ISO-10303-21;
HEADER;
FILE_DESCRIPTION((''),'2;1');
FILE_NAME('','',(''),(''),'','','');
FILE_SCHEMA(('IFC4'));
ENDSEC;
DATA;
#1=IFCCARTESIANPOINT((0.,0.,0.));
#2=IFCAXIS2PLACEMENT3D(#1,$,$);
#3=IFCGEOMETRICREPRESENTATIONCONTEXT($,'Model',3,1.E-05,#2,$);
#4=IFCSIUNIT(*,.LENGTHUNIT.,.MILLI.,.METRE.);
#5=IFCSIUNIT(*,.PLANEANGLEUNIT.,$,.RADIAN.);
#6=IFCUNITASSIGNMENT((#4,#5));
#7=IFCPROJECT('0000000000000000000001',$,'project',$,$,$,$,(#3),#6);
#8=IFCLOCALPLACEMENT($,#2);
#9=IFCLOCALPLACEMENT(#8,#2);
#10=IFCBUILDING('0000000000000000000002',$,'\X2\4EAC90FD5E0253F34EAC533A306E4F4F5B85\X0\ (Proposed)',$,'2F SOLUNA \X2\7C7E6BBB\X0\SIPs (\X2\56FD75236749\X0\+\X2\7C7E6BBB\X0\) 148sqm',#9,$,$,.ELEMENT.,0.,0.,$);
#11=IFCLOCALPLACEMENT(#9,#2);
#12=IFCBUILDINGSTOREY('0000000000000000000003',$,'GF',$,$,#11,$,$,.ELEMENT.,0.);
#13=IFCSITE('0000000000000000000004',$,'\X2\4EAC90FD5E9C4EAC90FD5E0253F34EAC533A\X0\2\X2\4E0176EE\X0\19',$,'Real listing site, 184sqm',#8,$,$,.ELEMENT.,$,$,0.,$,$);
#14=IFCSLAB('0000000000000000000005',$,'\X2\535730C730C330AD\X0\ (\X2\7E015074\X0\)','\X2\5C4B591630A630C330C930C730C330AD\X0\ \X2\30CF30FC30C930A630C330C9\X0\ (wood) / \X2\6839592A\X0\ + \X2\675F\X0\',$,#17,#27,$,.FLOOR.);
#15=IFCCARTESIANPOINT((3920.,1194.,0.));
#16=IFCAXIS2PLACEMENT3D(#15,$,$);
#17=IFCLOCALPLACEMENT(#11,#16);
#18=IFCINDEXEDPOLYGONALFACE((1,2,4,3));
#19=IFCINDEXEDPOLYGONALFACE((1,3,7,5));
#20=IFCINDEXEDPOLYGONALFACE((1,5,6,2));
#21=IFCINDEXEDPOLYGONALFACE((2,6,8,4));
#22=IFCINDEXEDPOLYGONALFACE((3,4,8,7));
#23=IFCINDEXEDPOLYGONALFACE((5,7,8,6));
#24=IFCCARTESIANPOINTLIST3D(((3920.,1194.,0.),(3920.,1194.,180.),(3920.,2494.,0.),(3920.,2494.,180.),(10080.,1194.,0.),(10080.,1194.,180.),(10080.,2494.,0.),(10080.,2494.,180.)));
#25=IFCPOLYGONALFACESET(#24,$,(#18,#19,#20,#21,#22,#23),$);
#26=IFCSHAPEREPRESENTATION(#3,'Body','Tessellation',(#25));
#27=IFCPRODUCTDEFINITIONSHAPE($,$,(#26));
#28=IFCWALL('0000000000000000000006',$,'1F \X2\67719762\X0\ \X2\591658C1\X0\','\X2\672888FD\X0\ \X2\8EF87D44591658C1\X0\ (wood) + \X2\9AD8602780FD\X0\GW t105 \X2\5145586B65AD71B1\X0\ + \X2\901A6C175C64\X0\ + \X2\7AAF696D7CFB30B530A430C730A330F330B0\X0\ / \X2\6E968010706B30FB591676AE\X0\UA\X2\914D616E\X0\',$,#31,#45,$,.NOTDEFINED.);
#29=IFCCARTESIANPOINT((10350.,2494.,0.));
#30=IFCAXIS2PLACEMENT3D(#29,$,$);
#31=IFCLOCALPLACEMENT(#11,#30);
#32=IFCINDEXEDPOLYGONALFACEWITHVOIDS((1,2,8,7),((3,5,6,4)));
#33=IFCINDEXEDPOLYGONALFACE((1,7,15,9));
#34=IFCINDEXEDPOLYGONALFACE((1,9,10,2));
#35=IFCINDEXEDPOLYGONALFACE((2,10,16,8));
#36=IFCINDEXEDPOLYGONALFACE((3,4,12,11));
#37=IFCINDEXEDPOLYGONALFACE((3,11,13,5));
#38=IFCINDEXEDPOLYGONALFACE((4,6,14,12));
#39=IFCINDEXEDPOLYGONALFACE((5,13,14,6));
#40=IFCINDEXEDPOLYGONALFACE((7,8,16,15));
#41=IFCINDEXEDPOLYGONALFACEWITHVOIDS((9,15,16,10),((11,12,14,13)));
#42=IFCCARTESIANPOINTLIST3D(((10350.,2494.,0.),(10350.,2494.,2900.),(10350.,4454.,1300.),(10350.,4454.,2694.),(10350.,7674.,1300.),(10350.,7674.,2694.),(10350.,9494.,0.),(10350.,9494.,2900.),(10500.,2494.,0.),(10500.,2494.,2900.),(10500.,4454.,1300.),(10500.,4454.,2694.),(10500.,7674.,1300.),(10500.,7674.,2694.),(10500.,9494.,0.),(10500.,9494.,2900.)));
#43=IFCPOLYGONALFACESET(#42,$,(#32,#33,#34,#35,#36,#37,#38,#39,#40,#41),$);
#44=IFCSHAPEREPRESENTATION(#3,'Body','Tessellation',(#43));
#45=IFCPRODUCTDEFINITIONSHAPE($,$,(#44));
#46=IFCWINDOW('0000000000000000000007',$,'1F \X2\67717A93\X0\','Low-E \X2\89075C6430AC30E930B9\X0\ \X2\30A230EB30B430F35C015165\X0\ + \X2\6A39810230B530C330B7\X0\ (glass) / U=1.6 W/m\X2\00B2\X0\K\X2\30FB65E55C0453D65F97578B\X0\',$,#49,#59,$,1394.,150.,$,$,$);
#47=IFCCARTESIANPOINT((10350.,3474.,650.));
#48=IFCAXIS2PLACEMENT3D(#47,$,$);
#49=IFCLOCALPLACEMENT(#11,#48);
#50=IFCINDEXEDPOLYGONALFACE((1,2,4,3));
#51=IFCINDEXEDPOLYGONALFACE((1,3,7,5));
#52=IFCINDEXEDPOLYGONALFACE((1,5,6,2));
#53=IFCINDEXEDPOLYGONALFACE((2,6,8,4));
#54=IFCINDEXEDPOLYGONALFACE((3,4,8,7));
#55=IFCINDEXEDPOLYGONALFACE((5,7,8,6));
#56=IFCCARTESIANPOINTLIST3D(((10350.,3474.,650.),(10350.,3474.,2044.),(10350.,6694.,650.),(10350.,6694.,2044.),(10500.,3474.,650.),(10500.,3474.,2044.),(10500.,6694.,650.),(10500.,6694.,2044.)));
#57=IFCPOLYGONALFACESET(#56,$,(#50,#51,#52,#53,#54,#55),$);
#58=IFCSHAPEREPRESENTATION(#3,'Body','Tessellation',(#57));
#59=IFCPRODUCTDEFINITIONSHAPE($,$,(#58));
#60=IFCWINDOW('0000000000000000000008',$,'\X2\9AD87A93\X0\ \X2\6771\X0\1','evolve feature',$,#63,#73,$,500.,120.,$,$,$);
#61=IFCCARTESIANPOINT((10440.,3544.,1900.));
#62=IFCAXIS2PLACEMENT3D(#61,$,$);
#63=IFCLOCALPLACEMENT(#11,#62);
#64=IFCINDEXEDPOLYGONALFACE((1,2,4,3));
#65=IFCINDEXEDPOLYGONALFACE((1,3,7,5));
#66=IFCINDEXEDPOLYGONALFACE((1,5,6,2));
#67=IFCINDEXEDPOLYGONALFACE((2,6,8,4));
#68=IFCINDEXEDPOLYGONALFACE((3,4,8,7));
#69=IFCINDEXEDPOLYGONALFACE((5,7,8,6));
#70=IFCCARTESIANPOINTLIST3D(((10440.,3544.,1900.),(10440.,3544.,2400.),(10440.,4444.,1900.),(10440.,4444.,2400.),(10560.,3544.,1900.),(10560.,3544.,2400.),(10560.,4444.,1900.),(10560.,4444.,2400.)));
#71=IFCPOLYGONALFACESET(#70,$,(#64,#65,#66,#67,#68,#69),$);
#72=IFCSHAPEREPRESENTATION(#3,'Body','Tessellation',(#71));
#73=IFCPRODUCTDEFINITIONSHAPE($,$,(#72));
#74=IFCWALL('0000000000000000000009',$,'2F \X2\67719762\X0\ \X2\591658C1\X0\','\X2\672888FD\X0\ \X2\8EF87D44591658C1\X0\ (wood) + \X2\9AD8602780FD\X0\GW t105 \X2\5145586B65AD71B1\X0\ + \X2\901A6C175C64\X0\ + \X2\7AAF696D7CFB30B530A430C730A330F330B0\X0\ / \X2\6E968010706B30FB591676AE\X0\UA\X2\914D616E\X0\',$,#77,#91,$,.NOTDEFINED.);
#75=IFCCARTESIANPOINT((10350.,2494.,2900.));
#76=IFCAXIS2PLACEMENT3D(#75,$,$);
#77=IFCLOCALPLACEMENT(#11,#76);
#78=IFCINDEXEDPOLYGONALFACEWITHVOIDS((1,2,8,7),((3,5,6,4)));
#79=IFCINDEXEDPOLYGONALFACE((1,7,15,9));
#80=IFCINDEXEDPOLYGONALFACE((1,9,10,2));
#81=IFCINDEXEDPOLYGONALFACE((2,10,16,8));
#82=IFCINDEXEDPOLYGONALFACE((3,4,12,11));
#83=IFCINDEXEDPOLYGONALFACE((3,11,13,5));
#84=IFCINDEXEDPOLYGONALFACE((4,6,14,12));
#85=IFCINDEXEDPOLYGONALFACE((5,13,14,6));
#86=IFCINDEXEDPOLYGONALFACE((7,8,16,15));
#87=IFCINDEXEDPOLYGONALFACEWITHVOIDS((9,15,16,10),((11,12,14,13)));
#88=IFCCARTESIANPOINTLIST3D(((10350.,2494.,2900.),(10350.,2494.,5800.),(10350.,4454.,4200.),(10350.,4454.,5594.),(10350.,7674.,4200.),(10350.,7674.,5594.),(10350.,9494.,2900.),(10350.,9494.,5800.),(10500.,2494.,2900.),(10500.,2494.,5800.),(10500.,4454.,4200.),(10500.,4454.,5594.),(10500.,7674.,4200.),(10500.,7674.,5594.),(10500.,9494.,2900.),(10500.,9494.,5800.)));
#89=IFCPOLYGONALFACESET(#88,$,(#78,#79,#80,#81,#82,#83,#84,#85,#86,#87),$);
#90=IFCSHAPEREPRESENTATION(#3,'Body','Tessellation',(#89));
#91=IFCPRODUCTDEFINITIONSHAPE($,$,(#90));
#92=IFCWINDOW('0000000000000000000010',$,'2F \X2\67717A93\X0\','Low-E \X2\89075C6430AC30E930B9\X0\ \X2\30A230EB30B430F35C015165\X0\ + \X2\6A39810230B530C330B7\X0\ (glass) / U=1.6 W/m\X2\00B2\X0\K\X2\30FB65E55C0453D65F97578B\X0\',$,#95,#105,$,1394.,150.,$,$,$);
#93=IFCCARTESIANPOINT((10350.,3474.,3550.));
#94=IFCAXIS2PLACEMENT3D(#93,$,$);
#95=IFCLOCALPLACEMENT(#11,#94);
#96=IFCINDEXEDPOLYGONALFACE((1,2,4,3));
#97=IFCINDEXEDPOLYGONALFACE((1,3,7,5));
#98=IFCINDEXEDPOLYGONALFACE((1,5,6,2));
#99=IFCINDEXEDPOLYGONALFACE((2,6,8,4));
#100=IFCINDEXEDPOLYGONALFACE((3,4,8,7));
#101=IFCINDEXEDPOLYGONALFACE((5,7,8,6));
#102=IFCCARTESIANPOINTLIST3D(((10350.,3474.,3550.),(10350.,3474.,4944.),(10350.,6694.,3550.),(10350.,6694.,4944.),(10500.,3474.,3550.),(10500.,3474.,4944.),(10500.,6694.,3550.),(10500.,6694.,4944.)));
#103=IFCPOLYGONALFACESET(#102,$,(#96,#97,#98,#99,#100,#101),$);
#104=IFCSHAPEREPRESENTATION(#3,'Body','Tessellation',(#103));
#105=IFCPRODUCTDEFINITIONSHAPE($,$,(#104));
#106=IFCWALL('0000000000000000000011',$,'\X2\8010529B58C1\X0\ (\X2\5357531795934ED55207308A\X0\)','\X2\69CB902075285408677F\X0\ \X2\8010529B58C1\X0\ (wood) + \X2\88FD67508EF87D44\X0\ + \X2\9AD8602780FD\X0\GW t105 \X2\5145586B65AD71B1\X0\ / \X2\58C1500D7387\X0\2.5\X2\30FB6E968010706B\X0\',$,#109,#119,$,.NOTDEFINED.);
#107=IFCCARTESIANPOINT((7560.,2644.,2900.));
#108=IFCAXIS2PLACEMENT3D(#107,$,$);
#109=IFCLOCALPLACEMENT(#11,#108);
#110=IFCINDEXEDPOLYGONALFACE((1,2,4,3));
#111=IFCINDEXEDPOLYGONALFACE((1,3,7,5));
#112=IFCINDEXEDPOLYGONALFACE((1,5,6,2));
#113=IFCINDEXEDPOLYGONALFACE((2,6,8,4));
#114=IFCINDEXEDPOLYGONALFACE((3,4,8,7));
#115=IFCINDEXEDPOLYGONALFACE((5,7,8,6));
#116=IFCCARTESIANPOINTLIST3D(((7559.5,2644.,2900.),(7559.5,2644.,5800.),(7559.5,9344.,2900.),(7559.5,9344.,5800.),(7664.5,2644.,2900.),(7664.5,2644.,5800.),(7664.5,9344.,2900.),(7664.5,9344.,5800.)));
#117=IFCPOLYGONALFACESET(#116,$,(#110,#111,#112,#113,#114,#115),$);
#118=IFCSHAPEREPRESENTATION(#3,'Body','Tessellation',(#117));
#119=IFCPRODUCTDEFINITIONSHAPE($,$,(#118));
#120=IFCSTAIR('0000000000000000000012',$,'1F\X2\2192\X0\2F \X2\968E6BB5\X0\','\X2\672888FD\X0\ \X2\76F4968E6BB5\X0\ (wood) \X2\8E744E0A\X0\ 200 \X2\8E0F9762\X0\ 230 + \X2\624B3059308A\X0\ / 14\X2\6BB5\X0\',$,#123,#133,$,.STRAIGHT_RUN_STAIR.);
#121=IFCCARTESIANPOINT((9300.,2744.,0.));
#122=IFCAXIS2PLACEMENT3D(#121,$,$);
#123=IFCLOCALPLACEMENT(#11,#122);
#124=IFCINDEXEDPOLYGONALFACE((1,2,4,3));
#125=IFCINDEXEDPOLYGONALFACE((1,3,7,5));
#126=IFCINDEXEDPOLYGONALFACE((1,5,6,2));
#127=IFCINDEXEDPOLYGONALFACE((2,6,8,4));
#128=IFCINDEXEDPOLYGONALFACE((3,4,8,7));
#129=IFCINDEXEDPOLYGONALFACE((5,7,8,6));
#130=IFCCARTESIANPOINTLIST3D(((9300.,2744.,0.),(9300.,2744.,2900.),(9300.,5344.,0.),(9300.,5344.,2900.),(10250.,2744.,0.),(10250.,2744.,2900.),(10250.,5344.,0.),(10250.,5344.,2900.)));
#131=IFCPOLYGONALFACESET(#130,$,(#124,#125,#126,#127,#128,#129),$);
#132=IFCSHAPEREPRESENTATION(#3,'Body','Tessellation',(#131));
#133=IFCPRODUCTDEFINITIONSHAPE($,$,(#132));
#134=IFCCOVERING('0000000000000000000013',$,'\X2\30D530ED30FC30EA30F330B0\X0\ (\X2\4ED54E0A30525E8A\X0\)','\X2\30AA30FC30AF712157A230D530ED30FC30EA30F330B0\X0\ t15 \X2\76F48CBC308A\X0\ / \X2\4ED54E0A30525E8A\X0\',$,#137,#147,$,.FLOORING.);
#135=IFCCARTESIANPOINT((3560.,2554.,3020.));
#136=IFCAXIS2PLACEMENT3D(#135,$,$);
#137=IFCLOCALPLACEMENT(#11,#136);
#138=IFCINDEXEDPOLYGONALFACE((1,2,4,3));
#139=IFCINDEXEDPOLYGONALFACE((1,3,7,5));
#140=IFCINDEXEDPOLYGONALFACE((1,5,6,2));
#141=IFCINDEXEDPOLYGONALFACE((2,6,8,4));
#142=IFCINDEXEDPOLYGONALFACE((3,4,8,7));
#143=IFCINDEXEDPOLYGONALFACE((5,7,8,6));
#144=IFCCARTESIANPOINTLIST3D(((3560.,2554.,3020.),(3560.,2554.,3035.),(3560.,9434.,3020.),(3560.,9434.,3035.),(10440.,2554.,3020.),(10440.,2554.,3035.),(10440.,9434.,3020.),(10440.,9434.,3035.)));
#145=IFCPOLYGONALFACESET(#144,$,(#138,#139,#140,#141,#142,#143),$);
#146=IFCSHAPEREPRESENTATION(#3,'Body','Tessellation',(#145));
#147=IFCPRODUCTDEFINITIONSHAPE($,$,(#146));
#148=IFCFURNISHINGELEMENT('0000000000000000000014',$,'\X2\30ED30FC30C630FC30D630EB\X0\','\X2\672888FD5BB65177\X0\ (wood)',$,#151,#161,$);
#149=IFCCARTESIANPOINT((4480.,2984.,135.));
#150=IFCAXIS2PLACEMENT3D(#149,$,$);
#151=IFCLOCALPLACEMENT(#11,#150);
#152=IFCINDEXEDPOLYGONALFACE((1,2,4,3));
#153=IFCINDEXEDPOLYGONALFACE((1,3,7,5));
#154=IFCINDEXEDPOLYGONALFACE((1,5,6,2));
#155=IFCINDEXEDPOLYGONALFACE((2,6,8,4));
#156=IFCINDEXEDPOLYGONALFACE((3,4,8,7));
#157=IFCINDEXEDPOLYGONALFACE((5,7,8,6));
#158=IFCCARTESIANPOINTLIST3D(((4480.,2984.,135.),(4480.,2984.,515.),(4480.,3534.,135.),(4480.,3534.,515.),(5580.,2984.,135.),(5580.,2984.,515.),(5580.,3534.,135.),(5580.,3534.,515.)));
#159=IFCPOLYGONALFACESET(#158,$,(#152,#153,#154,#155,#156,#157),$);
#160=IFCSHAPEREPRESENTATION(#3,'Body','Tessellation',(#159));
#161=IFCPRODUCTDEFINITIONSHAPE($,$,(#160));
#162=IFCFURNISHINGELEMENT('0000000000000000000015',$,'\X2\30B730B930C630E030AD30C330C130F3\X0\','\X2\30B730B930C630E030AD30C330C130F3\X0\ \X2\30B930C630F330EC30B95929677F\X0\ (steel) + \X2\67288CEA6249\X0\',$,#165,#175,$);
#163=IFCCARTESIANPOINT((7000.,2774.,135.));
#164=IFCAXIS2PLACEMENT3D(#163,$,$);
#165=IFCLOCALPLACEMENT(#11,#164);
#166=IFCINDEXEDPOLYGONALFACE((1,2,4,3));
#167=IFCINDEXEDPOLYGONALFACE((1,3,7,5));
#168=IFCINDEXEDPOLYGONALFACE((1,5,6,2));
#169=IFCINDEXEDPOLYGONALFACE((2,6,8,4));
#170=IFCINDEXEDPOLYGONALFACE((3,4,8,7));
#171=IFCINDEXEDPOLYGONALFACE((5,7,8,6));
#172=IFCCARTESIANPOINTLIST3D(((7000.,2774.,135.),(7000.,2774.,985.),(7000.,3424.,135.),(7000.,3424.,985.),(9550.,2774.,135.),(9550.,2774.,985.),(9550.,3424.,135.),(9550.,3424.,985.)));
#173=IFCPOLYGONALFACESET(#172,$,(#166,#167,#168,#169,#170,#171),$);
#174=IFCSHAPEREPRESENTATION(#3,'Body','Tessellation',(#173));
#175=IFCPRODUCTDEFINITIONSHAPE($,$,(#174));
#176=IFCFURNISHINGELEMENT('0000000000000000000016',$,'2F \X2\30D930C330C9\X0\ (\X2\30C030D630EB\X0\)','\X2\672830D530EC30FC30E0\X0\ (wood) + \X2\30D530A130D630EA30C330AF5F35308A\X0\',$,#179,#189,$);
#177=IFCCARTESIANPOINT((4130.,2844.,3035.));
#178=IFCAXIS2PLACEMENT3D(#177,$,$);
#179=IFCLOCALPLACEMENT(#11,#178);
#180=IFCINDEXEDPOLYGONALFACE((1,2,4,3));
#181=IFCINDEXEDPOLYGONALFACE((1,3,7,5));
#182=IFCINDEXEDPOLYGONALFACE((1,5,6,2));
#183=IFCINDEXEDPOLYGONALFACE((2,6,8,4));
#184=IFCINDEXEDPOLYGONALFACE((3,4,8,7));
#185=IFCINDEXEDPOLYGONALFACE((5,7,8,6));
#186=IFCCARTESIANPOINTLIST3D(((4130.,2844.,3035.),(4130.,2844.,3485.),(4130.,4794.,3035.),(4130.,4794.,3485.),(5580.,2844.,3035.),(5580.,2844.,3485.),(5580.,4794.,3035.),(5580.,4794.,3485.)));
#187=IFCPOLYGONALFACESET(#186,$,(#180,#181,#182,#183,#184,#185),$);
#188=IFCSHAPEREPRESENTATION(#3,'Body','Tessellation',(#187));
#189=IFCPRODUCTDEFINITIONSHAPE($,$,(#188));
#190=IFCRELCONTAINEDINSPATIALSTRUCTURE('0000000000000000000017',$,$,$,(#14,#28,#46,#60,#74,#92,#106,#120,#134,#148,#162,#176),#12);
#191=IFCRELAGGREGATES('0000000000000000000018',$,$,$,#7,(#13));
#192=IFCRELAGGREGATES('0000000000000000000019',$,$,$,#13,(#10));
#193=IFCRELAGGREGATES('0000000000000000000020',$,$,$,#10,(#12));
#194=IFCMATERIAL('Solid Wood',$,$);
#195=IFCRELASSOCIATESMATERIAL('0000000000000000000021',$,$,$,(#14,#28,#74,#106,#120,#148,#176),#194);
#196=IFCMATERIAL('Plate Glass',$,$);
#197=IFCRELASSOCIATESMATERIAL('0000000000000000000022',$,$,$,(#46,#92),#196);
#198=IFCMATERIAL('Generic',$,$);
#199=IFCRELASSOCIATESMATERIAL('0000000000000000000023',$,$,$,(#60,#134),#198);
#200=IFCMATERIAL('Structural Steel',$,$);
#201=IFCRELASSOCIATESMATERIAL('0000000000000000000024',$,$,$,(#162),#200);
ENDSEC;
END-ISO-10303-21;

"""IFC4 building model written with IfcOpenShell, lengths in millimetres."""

from ifc_helpers import new_model, si_unit, frame, frame_2d, origin, place, context, project, spatial, rectangle, extrude, material, element, fill, save


model = new_model("IFC4")

# Units and contexts
model_context = context("Model", 3, precision=1e-05, world=origin())
ifc_project = project(units=[si_unit("LENGTHUNIT", "METRE", prefix="MILLI"), si_unit("PLANEANGLEUNIT", "RADIAN")], contexts=[model_context])

# Site, building, storey
site_placement = place(None, origin())
site = spatial("IfcSite", under=ifc_project, at=site_placement, Name="京都府京都市右京区2丁目19", ObjectType="Real listing site, 184sqm", CompositionType="ELEMENT", RefElevation=0.0)
building_placement = place(site_placement, origin())
building = spatial("IfcBuilding", under=site, at=building_placement, Name="京都市右京区の住宅 (Proposed)", ObjectType="2F SOLUNA 籾殻SIPs (国産杉+籾殻) 148sqm", CompositionType="ELEMENT", ElevationOfRefHeight=0.0, ElevationOfTerrain=0.0)
storey_placement = place(building_placement, origin())
storey = spatial("IfcBuildingStorey", under=building, at=storey_placement, Name="GF", CompositionType="ELEMENT", Elevation=0.0)

# Slab
ifc_material_1 = material(Name="Solid Wood")
slab_placement = place(storey_placement, frame((3920.0, 1194.0, 0.0)))
element("IfcSlab", 1, at=slab_placement, inside=storey, material=ifc_material_1, Name="南デッキ (縁側)", Description="屋外ウッドデッキ ハードウッド (wood) / 根太 + 束", PredefinedType="FLOOR", context=model_context, shape_type="SweptSolid", body=[
    extrude(rectangle(XDim=6160.0, YDim=1300.0, at=frame_2d((3080.0, 650.0))), frame((3920.0, 1194.0, 0.0)), (0.0, 0.0, 1.0), 180.0),
])

# Wall, openings, windows
wall_1_placement = place(storey_placement, frame((10350.0, 2494.0, 0.0)))
wall_1 = element("IfcWall", 2, at=wall_1_placement, inside=storey, material=ifc_material_1, Name="1F 東面 外壁", Description="木製 軸組外壁 (wood) + 高性能GW t105 充填断熱 + 通気層 + 窯業系サイディング / 準耐火・外皮UA配慮", PredefinedType="NOTDEFINED", context=model_context, shape_type="SweptSolid", body=[
    extrude(rectangle(XDim=150.0, YDim=7000.0, at=frame_2d((75.0, 3500.0))), frame((10350.0, 2494.0, 0.0)), (0.0, 0.0, 1.0), 2900.0),
])
opening_1_placement = place(storey_placement, frame((10350.0, 3474.0, 650.0)))
opening_1 = element("IfcOpeningElement", 3, at=opening_1_placement, cuts=wall_1, PredefinedType="NOTDEFINED", context=model_context, shape_type="SweptSolid", body=[
    extrude(rectangle(XDim=150.0, YDim=3220.0, at=frame_2d((75.0, 1610.0))), frame((10350.0, 3474.0, 650.0)), (0.0, 0.0, 1.0), 1394.0),
])
opening_2_placement = place(storey_placement, frame((10440.0, 3544.0, 1900.0)))
opening_2 = element("IfcOpeningElement", 4, at=opening_2_placement, cuts=wall_1, PredefinedType="NOTDEFINED", context=model_context, shape_type="SweptSolid", body=[
    extrude(rectangle(XDim=120.0, YDim=900.0, at=frame_2d((60.0, 450.0))), frame((10440.0, 3544.0, 1900.0)), (0.0, 0.0, 1.0), 500.0),
])
ifc_material_2 = material(Name="Plate Glass")
window_1_placement = place(storey_placement, frame((10350.0, 3474.0, 650.0)))
window_1 = element("IfcWindow", 5, at=window_1_placement, inside=storey, material=ifc_material_2, Name="1F 東窓", Description="Low-E 複層ガラス アルゴン封入 + 樹脂サッシ (glass) / U=1.6 W/m²K・日射取得型", OverallHeight=1394.0, OverallWidth=150.0, context=model_context, shape_type="SweptSolid", body=[
    extrude(rectangle(XDim=150.0, YDim=3220.0, at=frame_2d((75.0, 1610.0))), frame((10350.0, 3474.0, 650.0)), (0.0, 0.0, 1.0), 1394.0),
])
fill(opening_1, window_1)
ifc_material_3 = material(Name="Generic")
window_2_placement = place(storey_placement, frame((10440.0, 3544.0, 1900.0)))
window_2 = element("IfcWindow", 6, at=window_2_placement, inside=storey, material=ifc_material_3, Name="高窓 東1", Description="evolve feature", OverallHeight=500.0, OverallWidth=120.0, context=model_context, shape_type="SweptSolid", body=[
    extrude(rectangle(XDim=120.0, YDim=900.0, at=frame_2d((60.0, 450.0))), frame((10440.0, 3544.0, 1900.0)), (0.0, 0.0, 1.0), 500.0),
])
fill(opening_2, window_2)

# Wall, opening, window
wall_2_placement = place(storey_placement, frame((10350.0, 2494.0, 2900.0)))
wall_2 = element("IfcWall", 7, at=wall_2_placement, inside=storey, material=ifc_material_1, Name="2F 東面 外壁", Description="木製 軸組外壁 (wood) + 高性能GW t105 充填断熱 + 通気層 + 窯業系サイディング / 準耐火・外皮UA配慮", PredefinedType="NOTDEFINED", context=model_context, shape_type="SweptSolid", body=[
    extrude(rectangle(XDim=150.0, YDim=7000.0, at=frame_2d((75.0, 3500.0))), frame((10350.0, 2494.0, 2900.0)), (0.0, 0.0, 1.0), 2900.0),
])
opening_3_placement = place(storey_placement, frame((10350.0, 3474.0, 3550.0)))
opening_3 = element("IfcOpeningElement", 8, at=opening_3_placement, cuts=wall_2, PredefinedType="NOTDEFINED", context=model_context, shape_type="SweptSolid", body=[
    extrude(rectangle(XDim=150.0, YDim=3220.0, at=frame_2d((75.0, 1610.0))), frame((10350.0, 3474.0, 3550.0)), (0.0, 0.0, 1.0), 1394.0),
])
window_3_placement = place(storey_placement, frame((10350.0, 3474.0, 3550.0)))
window_3 = element("IfcWindow", 9, at=window_3_placement, inside=storey, material=ifc_material_2, Name="2F 東窓", Description="Low-E 複層ガラス アルゴン封入 + 樹脂サッシ (glass) / U=1.6 W/m²K・日射取得型", OverallHeight=1394.0, OverallWidth=150.0, context=model_context, shape_type="SweptSolid", body=[
    extrude(rectangle(XDim=150.0, YDim=3220.0, at=frame_2d((75.0, 1610.0))), frame((10350.0, 3474.0, 3550.0)), (0.0, 0.0, 1.0), 1394.0),
])
fill(opening_3, window_3)

# Wall
wall_3_placement = place(storey_placement, frame((7560.0, 2644.0, 2900.0)))
element("IfcWall", 10, at=wall_3_placement, inside=storey, material=ifc_material_1, Name="耐力壁 (南北間仕切り)", Description="構造用合板 耐力壁 (wood) + 製材軸組 + 高性能GW t105 充填断熱 / 壁倍率2.5・準耐火", PredefinedType="NOTDEFINED", context=model_context, shape_type="SweptSolid", body=[
    extrude(rectangle(XDim=105.0, YDim=6700.0, at=frame_2d((52.0, 3350.0))), frame((7560.0, 2644.0, 2900.0)), (0.0, 0.0, 1.0), 2900.0),
])

# Stair
stair_placement = place(storey_placement, frame((9300.0, 2744.0, 0.0)))
element("IfcStair", 11, at=stair_placement, inside=storey, material=ifc_material_1, Name="1F→2F 階段", Description="木製 直階段 (wood) 蹴上 200 踏面 230 + 手すり / 14段", PredefinedType="STRAIGHT_RUN_STAIR", context=model_context, shape_type="SweptSolid", body=[
    extrude(rectangle(XDim=950.0, YDim=2600.0, at=frame_2d((475.0, 1300.0))), frame((9300.0, 2744.0, 0.0)), (0.0, 0.0, 1.0), 2900.0),
])

# Covering
covering_placement = place(storey_placement, frame((3560.0, 2554.0, 3020.0)))
element("IfcCovering", 12, at=covering_placement, inside=storey, material=ifc_material_3, Name="フローリング (仕上げ床)", Description="オーク無垢フローリング t15 直貼り / 仕上げ床", PredefinedType="FLOORING", context=model_context, shape_type="SweptSolid", body=[
    extrude(rectangle(XDim=6880.0, YDim=6880.0, at=frame_2d((3440.0, 3440.0))), frame((3560.0, 2554.0, 3020.0)), (0.0, 0.0, 1.0), 15.0),
])

# Furnishing elements
furnishing_1_placement = place(storey_placement, frame((4480.0, 2984.0, 135.0)))
element("IfcFurnishingElement", 13, at=furnishing_1_placement, inside=storey, material=ifc_material_1, Name="ローテーブル", Description="木製家具 (wood)", context=model_context, shape_type="SweptSolid", body=[
    extrude(rectangle(XDim=1100.0, YDim=550.0, at=frame_2d((550.0, 275.0))), frame((4480.0, 2984.0, 135.0)), (0.0, 0.0, 1.0), 380.0),
])
ifc_material_4 = material(Name="Structural Steel")
furnishing_2_placement = place(storey_placement, frame((7000.0, 2774.0, 135.0)))
element("IfcFurnishingElement", 14, at=furnishing_2_placement, inside=storey, material=ifc_material_4, Name="システムキッチン", Description="システムキッチン ステンレス天板 (steel) + 木質扉", context=model_context, shape_type="SweptSolid", body=[
    extrude(rectangle(XDim=2550.0, YDim=650.0, at=frame_2d((1275.0, 325.0))), frame((7000.0, 2774.0, 135.0)), (0.0, 0.0, 1.0), 850.0),
])
furnishing_3_placement = place(storey_placement, frame((4130.0, 2844.0, 3035.0)))
element("IfcFurnishingElement", 15, at=furnishing_3_placement, inside=storey, material=ifc_material_1, Name="2F ベッド (ダブル)", Description="木フレーム (wood) + ファブリック張り", context=model_context, shape_type="SweptSolid", body=[
    extrude(rectangle(XDim=1450.0, YDim=1950.0, at=frame_2d((725.0, 975.0))), frame((4130.0, 2844.0, 3035.0)), (0.0, 0.0, 1.0), 450.0),
])

save(model, "model.ifc")
